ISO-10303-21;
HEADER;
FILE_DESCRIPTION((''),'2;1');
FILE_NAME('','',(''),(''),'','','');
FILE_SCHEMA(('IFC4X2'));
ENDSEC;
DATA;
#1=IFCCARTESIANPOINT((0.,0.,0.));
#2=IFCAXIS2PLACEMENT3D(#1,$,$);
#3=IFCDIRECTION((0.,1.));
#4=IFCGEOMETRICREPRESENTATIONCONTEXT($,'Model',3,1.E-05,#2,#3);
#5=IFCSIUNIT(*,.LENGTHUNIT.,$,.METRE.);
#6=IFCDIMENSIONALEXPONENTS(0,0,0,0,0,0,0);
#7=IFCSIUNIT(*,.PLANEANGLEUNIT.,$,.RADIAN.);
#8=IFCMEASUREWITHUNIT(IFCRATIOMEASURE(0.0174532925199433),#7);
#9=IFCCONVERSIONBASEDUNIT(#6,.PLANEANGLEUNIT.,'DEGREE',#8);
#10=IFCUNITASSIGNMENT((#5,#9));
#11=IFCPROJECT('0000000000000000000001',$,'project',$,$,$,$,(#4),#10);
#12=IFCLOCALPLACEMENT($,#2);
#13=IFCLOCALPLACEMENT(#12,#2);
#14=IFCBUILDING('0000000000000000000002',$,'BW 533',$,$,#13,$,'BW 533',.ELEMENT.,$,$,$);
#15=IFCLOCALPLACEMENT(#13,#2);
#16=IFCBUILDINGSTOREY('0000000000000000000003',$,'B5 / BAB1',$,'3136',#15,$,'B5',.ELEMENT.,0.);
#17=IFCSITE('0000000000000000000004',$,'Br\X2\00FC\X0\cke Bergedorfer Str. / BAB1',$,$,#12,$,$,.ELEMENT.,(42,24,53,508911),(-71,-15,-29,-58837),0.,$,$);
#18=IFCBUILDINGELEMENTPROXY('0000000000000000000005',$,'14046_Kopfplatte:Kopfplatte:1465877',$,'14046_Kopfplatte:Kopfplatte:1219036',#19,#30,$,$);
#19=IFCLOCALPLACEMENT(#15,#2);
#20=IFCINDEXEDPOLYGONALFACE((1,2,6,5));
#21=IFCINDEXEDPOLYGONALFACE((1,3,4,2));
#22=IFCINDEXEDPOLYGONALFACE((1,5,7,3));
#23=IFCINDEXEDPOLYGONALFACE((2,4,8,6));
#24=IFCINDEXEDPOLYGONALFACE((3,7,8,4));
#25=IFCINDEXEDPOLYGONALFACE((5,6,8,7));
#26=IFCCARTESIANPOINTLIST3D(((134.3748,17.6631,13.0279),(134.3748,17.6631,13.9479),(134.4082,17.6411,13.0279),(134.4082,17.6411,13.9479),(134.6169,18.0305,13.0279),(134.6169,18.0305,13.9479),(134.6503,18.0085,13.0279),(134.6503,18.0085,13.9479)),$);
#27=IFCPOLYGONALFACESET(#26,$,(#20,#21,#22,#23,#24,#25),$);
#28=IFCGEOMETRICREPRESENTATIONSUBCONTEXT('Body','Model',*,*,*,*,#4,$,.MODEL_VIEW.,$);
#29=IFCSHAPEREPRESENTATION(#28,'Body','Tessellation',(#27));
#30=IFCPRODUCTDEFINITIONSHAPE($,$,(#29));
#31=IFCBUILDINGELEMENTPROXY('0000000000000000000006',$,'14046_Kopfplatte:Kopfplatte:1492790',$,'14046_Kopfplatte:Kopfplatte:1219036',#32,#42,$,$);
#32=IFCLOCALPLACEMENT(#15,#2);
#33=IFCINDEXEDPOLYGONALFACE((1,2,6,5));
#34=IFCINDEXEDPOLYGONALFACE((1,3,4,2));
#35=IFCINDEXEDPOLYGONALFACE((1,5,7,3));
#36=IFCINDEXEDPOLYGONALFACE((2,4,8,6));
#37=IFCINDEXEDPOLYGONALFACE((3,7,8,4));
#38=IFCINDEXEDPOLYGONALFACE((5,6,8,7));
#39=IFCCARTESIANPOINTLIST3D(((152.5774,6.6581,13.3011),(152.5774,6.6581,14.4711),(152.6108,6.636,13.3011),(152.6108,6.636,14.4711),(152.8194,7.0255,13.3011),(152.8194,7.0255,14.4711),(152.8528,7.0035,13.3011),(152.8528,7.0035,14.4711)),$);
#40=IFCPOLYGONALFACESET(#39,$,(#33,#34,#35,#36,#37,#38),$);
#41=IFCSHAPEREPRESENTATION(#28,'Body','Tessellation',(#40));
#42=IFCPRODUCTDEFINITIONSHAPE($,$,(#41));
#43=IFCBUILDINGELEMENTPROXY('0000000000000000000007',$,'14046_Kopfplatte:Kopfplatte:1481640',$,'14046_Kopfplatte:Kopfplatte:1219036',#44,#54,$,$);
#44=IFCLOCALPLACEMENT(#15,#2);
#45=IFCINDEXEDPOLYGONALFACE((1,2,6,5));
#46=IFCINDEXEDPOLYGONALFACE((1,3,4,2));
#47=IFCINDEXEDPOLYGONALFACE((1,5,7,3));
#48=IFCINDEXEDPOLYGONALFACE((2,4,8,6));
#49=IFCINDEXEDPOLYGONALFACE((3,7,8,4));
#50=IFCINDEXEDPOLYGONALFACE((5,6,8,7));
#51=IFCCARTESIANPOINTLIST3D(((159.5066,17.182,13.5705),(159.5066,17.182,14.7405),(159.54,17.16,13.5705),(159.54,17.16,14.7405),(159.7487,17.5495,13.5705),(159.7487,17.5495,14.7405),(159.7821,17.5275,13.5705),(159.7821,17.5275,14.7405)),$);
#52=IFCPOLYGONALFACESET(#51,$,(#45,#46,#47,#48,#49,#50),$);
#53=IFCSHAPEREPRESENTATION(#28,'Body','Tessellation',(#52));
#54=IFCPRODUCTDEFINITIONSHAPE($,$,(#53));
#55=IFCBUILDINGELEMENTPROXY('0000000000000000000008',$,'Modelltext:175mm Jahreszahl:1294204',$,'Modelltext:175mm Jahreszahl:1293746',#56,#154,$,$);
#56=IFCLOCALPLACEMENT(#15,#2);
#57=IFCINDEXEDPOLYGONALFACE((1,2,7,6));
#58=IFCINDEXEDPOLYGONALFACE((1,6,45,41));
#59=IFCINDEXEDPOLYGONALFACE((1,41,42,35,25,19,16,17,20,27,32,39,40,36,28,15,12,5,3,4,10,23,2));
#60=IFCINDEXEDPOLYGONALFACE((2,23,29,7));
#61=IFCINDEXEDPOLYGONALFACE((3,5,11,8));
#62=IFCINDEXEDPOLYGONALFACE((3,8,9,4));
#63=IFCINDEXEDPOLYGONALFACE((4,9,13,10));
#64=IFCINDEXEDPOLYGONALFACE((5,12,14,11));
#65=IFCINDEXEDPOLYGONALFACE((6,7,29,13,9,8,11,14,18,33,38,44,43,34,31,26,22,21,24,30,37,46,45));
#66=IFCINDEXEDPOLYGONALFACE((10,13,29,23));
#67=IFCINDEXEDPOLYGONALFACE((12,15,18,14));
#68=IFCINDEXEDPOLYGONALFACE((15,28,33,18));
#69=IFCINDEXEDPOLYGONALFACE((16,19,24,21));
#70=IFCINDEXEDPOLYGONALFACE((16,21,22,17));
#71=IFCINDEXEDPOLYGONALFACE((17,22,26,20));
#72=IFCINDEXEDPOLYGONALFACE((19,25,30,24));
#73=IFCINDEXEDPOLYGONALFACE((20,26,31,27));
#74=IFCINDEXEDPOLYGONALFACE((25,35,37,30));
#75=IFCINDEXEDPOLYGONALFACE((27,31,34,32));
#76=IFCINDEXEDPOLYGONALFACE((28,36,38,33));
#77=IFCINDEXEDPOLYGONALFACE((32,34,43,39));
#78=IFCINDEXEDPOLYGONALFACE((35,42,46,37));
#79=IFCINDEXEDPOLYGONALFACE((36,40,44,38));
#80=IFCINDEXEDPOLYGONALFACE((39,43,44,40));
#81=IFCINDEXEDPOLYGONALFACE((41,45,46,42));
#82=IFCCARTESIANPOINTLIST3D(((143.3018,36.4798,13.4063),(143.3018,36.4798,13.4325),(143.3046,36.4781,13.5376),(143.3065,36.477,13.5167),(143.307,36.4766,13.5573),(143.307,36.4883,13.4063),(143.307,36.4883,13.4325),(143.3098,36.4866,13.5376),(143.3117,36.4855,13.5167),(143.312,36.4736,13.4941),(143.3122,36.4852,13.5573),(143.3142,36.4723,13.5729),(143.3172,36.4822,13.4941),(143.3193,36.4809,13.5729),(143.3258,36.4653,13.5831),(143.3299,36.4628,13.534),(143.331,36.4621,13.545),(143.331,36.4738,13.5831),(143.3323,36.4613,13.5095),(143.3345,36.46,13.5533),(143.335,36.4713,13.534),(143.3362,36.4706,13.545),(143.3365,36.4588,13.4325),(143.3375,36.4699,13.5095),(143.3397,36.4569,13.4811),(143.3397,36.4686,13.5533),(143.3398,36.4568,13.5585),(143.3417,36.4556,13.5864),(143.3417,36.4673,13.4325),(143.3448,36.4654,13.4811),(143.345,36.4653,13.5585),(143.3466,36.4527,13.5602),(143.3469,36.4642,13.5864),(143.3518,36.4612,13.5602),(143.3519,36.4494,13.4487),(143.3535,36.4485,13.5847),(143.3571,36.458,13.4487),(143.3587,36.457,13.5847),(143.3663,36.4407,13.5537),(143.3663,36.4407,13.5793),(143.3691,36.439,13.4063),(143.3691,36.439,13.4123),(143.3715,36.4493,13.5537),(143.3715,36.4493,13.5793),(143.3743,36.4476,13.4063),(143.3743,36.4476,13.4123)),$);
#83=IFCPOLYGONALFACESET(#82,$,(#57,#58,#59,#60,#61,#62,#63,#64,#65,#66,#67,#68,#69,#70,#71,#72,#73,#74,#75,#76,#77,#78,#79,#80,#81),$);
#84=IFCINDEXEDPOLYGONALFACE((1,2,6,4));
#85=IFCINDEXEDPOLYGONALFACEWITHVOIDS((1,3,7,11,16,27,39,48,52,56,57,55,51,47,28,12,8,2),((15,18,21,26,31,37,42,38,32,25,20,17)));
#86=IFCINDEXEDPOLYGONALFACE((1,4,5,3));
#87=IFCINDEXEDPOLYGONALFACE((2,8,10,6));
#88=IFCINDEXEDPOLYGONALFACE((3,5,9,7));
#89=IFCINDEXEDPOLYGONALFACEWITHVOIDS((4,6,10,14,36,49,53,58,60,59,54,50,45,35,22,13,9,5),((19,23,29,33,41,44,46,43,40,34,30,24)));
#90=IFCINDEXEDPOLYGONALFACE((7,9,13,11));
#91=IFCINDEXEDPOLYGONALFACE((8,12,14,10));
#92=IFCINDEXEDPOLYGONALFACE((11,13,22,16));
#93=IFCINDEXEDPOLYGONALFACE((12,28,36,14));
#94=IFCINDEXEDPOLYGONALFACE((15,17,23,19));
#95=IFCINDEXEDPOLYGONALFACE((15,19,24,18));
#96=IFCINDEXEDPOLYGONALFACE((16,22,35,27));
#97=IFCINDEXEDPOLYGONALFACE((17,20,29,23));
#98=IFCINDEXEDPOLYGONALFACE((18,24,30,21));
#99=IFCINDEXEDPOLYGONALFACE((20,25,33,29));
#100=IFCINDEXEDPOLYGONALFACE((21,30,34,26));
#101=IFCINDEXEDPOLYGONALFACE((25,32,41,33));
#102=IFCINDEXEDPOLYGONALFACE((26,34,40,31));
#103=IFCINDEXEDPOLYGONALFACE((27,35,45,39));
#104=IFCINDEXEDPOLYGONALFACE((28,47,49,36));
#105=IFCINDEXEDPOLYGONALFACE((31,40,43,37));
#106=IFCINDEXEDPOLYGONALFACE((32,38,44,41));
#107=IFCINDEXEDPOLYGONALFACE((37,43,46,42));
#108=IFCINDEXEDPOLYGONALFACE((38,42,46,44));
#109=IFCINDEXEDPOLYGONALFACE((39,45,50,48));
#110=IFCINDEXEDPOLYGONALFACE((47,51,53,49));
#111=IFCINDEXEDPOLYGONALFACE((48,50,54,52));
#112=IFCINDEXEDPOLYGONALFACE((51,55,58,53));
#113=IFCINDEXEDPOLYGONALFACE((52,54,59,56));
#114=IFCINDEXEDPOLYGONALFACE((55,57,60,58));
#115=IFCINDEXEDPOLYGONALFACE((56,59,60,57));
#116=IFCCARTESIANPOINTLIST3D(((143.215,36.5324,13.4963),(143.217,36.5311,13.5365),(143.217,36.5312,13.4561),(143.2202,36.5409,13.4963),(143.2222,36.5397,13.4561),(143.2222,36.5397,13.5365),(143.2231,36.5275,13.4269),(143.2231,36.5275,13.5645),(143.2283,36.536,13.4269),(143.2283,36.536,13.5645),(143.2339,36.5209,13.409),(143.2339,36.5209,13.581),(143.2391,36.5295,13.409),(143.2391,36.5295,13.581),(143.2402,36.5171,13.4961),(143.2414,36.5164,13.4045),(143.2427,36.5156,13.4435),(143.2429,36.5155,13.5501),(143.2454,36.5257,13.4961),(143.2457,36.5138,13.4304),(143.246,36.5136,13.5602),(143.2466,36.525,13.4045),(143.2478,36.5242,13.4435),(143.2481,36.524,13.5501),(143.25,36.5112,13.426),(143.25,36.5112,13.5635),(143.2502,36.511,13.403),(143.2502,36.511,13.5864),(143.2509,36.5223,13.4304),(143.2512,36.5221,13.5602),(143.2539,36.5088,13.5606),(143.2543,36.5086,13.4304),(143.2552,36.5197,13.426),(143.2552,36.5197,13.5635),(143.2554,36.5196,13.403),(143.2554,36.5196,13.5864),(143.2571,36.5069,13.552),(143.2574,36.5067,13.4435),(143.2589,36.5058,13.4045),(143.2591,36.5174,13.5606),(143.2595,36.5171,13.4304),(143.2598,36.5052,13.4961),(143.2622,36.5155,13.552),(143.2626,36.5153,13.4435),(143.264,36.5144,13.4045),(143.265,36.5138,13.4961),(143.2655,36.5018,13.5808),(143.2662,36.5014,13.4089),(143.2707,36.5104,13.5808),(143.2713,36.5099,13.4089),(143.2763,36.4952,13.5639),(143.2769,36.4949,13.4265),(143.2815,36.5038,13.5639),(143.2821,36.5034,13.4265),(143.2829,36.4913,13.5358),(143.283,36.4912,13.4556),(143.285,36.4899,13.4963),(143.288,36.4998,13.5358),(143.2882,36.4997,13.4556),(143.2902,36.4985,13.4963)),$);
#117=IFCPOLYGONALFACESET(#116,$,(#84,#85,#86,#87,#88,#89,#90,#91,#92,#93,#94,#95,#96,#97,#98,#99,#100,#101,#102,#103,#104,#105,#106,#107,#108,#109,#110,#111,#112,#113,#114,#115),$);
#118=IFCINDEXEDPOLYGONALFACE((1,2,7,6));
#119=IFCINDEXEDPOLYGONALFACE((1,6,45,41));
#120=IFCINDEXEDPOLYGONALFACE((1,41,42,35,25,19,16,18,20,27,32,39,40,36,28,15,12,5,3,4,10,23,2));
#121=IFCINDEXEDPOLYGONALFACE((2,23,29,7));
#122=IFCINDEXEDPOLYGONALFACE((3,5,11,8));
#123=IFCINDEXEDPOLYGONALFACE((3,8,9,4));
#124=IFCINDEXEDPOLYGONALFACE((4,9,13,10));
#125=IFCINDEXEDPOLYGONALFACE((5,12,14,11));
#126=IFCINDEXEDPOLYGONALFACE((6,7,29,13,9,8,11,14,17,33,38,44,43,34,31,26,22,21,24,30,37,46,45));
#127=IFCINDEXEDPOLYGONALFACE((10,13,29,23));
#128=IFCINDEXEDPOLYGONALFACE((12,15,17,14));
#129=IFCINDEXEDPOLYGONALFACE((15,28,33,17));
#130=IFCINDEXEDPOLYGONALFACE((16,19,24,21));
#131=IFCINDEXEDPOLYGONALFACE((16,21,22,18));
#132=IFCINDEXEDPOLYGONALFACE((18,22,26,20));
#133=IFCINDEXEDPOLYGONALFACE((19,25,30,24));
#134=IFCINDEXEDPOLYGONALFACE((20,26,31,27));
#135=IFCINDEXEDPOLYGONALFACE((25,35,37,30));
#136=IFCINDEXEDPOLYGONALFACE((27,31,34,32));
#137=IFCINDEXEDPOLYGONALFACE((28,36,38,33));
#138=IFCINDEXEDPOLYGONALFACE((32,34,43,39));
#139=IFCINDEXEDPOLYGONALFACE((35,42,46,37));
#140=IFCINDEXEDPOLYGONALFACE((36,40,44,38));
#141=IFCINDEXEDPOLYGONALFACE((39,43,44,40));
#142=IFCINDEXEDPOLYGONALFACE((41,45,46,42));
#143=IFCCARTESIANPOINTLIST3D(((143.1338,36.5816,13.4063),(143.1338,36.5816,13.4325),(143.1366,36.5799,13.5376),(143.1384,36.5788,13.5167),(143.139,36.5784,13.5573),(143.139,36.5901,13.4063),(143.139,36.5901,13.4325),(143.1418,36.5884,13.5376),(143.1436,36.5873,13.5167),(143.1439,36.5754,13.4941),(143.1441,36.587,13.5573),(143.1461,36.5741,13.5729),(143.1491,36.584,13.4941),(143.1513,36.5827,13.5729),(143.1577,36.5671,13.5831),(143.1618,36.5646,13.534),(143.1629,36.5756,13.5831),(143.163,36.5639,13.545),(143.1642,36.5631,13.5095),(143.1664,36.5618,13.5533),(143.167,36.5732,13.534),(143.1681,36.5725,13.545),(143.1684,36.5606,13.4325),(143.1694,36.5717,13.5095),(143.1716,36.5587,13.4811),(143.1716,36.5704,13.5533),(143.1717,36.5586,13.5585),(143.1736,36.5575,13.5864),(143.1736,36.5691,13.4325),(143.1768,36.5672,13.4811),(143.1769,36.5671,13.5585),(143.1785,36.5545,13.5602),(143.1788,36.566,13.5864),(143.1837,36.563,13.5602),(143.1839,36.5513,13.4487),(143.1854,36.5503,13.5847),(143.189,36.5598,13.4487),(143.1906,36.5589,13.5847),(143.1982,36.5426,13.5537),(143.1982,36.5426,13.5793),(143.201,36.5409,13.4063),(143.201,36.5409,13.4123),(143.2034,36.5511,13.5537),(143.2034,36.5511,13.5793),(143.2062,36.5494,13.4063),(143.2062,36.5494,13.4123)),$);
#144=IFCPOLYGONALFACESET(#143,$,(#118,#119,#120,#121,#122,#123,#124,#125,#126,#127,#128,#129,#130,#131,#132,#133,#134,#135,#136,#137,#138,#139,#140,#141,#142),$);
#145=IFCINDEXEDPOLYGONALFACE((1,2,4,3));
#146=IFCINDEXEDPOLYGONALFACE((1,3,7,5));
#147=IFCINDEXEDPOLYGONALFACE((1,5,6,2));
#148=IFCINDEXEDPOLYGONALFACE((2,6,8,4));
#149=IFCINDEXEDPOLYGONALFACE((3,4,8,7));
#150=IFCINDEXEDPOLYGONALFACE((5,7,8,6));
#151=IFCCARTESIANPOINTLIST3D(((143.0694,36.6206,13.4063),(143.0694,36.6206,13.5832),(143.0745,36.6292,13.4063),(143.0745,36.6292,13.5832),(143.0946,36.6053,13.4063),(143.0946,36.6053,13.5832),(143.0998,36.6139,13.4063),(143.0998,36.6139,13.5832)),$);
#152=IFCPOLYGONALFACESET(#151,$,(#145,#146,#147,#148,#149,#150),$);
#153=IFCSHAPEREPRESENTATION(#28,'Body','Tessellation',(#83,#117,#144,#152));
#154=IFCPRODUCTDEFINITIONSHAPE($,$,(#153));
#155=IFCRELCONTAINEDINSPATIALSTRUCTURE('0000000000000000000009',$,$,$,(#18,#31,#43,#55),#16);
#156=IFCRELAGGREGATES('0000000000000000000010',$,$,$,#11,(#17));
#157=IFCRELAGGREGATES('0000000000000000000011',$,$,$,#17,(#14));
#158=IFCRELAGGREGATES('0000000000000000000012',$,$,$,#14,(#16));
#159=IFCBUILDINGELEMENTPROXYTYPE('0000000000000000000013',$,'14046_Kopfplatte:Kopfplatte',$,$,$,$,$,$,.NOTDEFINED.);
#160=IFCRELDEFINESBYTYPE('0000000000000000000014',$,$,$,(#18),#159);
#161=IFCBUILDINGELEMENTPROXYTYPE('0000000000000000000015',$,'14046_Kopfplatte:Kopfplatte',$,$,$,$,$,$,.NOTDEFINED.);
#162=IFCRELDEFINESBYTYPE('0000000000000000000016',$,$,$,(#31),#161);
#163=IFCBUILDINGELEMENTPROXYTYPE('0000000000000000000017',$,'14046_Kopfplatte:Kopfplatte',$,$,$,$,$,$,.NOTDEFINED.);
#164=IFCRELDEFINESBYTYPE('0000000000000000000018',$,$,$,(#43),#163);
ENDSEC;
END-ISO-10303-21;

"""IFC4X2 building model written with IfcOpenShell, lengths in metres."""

from ifc_helpers import new_model, entity, si_unit, converted_unit, direction, frame, frame_2d, origin, origin_2d_with_axis, place, context, subcontext, project, spatial, polyline, rectangle, outline, extrude, source, transform, mapped, type_object, type_shapes, element, save


model = new_model("IFC4X2")

# Units and contexts
model_context = context("Model", 3, precision=1e-05, world=origin(), true_north=direction((0.0, 1.0)))
body_context = subcontext(model_context, "Body", "Model", "MODEL_VIEW")
ifc_project = project(units=[si_unit("LENGTHUNIT", "METRE"), converted_unit("PLANEANGLEUNIT", "DEGREE", entity("IfcRatioMeasure", 0.0174532925199433), si_unit("PLANEANGLEUNIT", "RADIAN"), dimensions=[0, 0, 0, 0, 0, 0, 0])], contexts=[model_context])

# Site, building, storey
site_placement = place(None, origin())
site = spatial("IfcSite", under=ifc_project, at=site_placement, Name="Brücke Bergedorfer Str. / BAB1", CompositionType="ELEMENT", RefLatitude=(42, 24, 53, 508911), RefLongitude=(-71, -15, -29, -58837), RefElevation=0.0)
building_placement = place(site_placement, origin())
building = spatial("IfcBuilding", under=site, at=building_placement, Name="BW 533", LongName="BW 533", CompositionType="ELEMENT")
storey_placement = place(building_placement, origin())
storey = spatial("IfcBuildingStorey", under=building, at=storey_placement, Name="B5 / BAB1", ObjectType="3136", LongName="B5", CompositionType="ELEMENT", Elevation=0.0)

# Building element proxies
building_element_proxy_type_1 = type_object("IfcBuildingElementProxyType", Name="14046_Kopfplatte:Kopfplatte", PredefinedType="NOTDEFINED")
shared_shape_1 = source(origin(), body_context, "Body", "SweptSolid", [
    extrude(rectangle(XDim=0.04, YDim=0.44, at=frame_2d((0.0, 0.0), x_axis=(1.0, 0.0))), frame((134.5126, 17.8358, 13.0279), z_axis=(0.0, 0.0, 1.0), x_axis=(-0.835088, 0.550116, 0.0)), (0.0, 0.0, 1.0), 0.92),
])
type_shapes(building_element_proxy_type_1, [shared_shape_1])
proxy_1_placement = place(storey_placement, origin())
element("IfcBuildingElementProxy", 1, at=proxy_1_placement, inside=storey, type_object=building_element_proxy_type_1, Name="14046_Kopfplatte:Kopfplatte:1465877", ObjectType="14046_Kopfplatte:Kopfplatte:1219036", context=body_context, shape_type="MappedRepresentation", body=[
    mapped(shared_shape_1, transform((0.0, 0.0, 0.0), scale=1.0)),
])
building_element_proxy_type_2 = type_object("IfcBuildingElementProxyType", Name="14046_Kopfplatte:Kopfplatte", PredefinedType="NOTDEFINED")
shared_shape_2 = source(origin(), body_context, "Body", "SweptSolid", [
    extrude(rectangle(XDim=0.04, YDim=0.44, at=origin_2d_with_axis()), frame((152.7151, 6.8308, 13.3011), z_axis=(0.0, 0.0, 1.0), x_axis=(0.835088, -0.550116, 0.0)), (0.0, 0.0, 1.0), 1.17),
])
type_shapes(building_element_proxy_type_2, [shared_shape_2])
proxy_2_placement = place(storey_placement, origin())
element("IfcBuildingElementProxy", 2, at=proxy_2_placement, inside=storey, type_object=building_element_proxy_type_2, Name="14046_Kopfplatte:Kopfplatte:1492790", ObjectType="14046_Kopfplatte:Kopfplatte:1219036", context=body_context, shape_type="MappedRepresentation", body=[
    mapped(shared_shape_2, transform((0.0, 0.0, 0.0), scale=1.0)),
])
building_element_proxy_type_3 = type_object("IfcBuildingElementProxyType", Name="14046_Kopfplatte:Kopfplatte", PredefinedType="NOTDEFINED")
shared_shape_3 = source(origin(), body_context, "Body", "SweptSolid", [
    extrude(rectangle(XDim=0.04, YDim=0.44, at=frame_2d((0.0, 0.0), x_axis=(1.0, 0.0))), frame((159.6443, 17.3547, 13.5705), z_axis=(0.0, 0.0, 1.0), x_axis=(0.835088, -0.550116, 0.0)), (0.0, 0.0, 1.0), 1.17),
])
type_shapes(building_element_proxy_type_3, [shared_shape_3])
proxy_3_placement = place(storey_placement, origin())
element("IfcBuildingElementProxy", 3, at=proxy_3_placement, inside=storey, type_object=building_element_proxy_type_3, Name="14046_Kopfplatte:Kopfplatte:1481640", ObjectType="14046_Kopfplatte:Kopfplatte:1219036", context=body_context, shape_type="MappedRepresentation", body=[
    mapped(shared_shape_3, transform((0.0, 0.0, 0.0), scale=1.0)),
])
proxy_4_placement = place(storey_placement, origin())
element("IfcBuildingElementProxy", 4, at=proxy_4_placement, inside=storey, Name="Modelltext:175mm Jahreszahl:1294204", ObjectType="Modelltext:175mm Jahreszahl:1293746", context=body_context, shape_type="SweptSolid", body=[
    extrude(outline(polyline([(-0.041, -0.1087), (0.0376, -0.1087), (0.0376, -0.0825), (-0.0029, -0.0825), (0.0257, -0.021), (0.0322, 0.0016), (0.0343, 0.0226), (0.0315, 0.0423), (0.0232, 0.0579), (0.0096, 0.068), (-0.009, 0.0714), (-0.0228, 0.0696), (-0.0377, 0.0643), (-0.0377, 0.0386), (-0.0147, 0.0452), (-0.0068, 0.0434), (-0.0006, 0.0382), (0.0035, 0.0299), (0.0048, 0.019), (0.002, -0.0055), (-0.0066, -0.034), (-0.021, -0.0664), (-0.041, -0.1027), (-0.041, -0.1087)])), frame((143.334, 36.4603, 13.515), z_axis=(0.518179, 0.855272, 0.0), x_axis=(-0.855272, 0.518179, 0.0)), (0.0, 0.0, 1.0), 0.01),
    extrude(outline(polyline([(-0.012, -0.0814), (-0.0015, -0.0814), (0.0078, -0.0783), (0.0228, -0.0624), (0.034, -0.0344), (0.042, 0.005), (0.0454, 0.0451), (0.0423, 0.0739), (0.0321, 0.092), (0.0141, 0.1001), (-0.0044, 0.097), (-0.0194, 0.0821), (-0.0309, 0.0553), (-0.039, 0.0167), (-0.0424, -0.024), (-0.0395, -0.0538), (-0.0296, -0.073), (-0.0218, -0.0786), (-0.012, -0.0814)]), holes=[polyline([(0.0128, 0.009), (0.0025, -0.0427), (-0.0029, -0.0552), (-0.0084, -0.0588), (-0.0128, -0.0537), (-0.0145, -0.0402), (-0.0099, 0.0123), (0.0013, 0.0671), (0.0062, 0.0752), (0.0111, 0.0774), (0.0152, 0.0734), (0.0174, 0.0629), (0.0128, 0.009)])]), frame((143.25, 36.5112, 13.4854), z_axis=(0.518179, 0.855272, 0.0), x_axis=(-0.846595, 0.512922, 0.142084)), (0.0, 0.0, 1.0), 0.01),
    extrude(outline(polyline([(-0.041, -0.1087), (0.0376, -0.1087), (0.0376, -0.0825), (-0.0029, -0.0825), (0.0257, -0.021), (0.0322, 0.0016), (0.0343, 0.0226), (0.0315, 0.0423), (0.0232, 0.0579), (0.0096, 0.068), (-0.009, 0.0714), (-0.0228, 0.0696), (-0.0377, 0.0643), (-0.0377, 0.0386), (-0.0147, 0.0452), (-0.0068, 0.0434), (-0.0006, 0.0382), (0.0035, 0.0299), (0.0048, 0.019), (0.002, -0.0055), (-0.0066, -0.034), (-0.021, -0.0664), (-0.041, -0.1027), (-0.041, -0.1087)])), frame((143.1659, 36.5621, 13.515), z_axis=(0.518179, 0.855272, 0.0), x_axis=(-0.855272, 0.518179, 0.0)), (0.0, 0.0, 1.0), 0.01),
    extrude(rectangle(XDim=0.01, YDim=0.0295, at=frame_2d((0.0, 0.0), x_axis=(1.0, 0.0))), frame((143.0846, 36.6173, 13.4063), z_axis=(0.0, 0.0, 1.0), x_axis=(-0.518179, -0.855272, 0.0)), (0.0, 0.0, 1.0), 0.1768),
])

save(model, "model.ifc")
